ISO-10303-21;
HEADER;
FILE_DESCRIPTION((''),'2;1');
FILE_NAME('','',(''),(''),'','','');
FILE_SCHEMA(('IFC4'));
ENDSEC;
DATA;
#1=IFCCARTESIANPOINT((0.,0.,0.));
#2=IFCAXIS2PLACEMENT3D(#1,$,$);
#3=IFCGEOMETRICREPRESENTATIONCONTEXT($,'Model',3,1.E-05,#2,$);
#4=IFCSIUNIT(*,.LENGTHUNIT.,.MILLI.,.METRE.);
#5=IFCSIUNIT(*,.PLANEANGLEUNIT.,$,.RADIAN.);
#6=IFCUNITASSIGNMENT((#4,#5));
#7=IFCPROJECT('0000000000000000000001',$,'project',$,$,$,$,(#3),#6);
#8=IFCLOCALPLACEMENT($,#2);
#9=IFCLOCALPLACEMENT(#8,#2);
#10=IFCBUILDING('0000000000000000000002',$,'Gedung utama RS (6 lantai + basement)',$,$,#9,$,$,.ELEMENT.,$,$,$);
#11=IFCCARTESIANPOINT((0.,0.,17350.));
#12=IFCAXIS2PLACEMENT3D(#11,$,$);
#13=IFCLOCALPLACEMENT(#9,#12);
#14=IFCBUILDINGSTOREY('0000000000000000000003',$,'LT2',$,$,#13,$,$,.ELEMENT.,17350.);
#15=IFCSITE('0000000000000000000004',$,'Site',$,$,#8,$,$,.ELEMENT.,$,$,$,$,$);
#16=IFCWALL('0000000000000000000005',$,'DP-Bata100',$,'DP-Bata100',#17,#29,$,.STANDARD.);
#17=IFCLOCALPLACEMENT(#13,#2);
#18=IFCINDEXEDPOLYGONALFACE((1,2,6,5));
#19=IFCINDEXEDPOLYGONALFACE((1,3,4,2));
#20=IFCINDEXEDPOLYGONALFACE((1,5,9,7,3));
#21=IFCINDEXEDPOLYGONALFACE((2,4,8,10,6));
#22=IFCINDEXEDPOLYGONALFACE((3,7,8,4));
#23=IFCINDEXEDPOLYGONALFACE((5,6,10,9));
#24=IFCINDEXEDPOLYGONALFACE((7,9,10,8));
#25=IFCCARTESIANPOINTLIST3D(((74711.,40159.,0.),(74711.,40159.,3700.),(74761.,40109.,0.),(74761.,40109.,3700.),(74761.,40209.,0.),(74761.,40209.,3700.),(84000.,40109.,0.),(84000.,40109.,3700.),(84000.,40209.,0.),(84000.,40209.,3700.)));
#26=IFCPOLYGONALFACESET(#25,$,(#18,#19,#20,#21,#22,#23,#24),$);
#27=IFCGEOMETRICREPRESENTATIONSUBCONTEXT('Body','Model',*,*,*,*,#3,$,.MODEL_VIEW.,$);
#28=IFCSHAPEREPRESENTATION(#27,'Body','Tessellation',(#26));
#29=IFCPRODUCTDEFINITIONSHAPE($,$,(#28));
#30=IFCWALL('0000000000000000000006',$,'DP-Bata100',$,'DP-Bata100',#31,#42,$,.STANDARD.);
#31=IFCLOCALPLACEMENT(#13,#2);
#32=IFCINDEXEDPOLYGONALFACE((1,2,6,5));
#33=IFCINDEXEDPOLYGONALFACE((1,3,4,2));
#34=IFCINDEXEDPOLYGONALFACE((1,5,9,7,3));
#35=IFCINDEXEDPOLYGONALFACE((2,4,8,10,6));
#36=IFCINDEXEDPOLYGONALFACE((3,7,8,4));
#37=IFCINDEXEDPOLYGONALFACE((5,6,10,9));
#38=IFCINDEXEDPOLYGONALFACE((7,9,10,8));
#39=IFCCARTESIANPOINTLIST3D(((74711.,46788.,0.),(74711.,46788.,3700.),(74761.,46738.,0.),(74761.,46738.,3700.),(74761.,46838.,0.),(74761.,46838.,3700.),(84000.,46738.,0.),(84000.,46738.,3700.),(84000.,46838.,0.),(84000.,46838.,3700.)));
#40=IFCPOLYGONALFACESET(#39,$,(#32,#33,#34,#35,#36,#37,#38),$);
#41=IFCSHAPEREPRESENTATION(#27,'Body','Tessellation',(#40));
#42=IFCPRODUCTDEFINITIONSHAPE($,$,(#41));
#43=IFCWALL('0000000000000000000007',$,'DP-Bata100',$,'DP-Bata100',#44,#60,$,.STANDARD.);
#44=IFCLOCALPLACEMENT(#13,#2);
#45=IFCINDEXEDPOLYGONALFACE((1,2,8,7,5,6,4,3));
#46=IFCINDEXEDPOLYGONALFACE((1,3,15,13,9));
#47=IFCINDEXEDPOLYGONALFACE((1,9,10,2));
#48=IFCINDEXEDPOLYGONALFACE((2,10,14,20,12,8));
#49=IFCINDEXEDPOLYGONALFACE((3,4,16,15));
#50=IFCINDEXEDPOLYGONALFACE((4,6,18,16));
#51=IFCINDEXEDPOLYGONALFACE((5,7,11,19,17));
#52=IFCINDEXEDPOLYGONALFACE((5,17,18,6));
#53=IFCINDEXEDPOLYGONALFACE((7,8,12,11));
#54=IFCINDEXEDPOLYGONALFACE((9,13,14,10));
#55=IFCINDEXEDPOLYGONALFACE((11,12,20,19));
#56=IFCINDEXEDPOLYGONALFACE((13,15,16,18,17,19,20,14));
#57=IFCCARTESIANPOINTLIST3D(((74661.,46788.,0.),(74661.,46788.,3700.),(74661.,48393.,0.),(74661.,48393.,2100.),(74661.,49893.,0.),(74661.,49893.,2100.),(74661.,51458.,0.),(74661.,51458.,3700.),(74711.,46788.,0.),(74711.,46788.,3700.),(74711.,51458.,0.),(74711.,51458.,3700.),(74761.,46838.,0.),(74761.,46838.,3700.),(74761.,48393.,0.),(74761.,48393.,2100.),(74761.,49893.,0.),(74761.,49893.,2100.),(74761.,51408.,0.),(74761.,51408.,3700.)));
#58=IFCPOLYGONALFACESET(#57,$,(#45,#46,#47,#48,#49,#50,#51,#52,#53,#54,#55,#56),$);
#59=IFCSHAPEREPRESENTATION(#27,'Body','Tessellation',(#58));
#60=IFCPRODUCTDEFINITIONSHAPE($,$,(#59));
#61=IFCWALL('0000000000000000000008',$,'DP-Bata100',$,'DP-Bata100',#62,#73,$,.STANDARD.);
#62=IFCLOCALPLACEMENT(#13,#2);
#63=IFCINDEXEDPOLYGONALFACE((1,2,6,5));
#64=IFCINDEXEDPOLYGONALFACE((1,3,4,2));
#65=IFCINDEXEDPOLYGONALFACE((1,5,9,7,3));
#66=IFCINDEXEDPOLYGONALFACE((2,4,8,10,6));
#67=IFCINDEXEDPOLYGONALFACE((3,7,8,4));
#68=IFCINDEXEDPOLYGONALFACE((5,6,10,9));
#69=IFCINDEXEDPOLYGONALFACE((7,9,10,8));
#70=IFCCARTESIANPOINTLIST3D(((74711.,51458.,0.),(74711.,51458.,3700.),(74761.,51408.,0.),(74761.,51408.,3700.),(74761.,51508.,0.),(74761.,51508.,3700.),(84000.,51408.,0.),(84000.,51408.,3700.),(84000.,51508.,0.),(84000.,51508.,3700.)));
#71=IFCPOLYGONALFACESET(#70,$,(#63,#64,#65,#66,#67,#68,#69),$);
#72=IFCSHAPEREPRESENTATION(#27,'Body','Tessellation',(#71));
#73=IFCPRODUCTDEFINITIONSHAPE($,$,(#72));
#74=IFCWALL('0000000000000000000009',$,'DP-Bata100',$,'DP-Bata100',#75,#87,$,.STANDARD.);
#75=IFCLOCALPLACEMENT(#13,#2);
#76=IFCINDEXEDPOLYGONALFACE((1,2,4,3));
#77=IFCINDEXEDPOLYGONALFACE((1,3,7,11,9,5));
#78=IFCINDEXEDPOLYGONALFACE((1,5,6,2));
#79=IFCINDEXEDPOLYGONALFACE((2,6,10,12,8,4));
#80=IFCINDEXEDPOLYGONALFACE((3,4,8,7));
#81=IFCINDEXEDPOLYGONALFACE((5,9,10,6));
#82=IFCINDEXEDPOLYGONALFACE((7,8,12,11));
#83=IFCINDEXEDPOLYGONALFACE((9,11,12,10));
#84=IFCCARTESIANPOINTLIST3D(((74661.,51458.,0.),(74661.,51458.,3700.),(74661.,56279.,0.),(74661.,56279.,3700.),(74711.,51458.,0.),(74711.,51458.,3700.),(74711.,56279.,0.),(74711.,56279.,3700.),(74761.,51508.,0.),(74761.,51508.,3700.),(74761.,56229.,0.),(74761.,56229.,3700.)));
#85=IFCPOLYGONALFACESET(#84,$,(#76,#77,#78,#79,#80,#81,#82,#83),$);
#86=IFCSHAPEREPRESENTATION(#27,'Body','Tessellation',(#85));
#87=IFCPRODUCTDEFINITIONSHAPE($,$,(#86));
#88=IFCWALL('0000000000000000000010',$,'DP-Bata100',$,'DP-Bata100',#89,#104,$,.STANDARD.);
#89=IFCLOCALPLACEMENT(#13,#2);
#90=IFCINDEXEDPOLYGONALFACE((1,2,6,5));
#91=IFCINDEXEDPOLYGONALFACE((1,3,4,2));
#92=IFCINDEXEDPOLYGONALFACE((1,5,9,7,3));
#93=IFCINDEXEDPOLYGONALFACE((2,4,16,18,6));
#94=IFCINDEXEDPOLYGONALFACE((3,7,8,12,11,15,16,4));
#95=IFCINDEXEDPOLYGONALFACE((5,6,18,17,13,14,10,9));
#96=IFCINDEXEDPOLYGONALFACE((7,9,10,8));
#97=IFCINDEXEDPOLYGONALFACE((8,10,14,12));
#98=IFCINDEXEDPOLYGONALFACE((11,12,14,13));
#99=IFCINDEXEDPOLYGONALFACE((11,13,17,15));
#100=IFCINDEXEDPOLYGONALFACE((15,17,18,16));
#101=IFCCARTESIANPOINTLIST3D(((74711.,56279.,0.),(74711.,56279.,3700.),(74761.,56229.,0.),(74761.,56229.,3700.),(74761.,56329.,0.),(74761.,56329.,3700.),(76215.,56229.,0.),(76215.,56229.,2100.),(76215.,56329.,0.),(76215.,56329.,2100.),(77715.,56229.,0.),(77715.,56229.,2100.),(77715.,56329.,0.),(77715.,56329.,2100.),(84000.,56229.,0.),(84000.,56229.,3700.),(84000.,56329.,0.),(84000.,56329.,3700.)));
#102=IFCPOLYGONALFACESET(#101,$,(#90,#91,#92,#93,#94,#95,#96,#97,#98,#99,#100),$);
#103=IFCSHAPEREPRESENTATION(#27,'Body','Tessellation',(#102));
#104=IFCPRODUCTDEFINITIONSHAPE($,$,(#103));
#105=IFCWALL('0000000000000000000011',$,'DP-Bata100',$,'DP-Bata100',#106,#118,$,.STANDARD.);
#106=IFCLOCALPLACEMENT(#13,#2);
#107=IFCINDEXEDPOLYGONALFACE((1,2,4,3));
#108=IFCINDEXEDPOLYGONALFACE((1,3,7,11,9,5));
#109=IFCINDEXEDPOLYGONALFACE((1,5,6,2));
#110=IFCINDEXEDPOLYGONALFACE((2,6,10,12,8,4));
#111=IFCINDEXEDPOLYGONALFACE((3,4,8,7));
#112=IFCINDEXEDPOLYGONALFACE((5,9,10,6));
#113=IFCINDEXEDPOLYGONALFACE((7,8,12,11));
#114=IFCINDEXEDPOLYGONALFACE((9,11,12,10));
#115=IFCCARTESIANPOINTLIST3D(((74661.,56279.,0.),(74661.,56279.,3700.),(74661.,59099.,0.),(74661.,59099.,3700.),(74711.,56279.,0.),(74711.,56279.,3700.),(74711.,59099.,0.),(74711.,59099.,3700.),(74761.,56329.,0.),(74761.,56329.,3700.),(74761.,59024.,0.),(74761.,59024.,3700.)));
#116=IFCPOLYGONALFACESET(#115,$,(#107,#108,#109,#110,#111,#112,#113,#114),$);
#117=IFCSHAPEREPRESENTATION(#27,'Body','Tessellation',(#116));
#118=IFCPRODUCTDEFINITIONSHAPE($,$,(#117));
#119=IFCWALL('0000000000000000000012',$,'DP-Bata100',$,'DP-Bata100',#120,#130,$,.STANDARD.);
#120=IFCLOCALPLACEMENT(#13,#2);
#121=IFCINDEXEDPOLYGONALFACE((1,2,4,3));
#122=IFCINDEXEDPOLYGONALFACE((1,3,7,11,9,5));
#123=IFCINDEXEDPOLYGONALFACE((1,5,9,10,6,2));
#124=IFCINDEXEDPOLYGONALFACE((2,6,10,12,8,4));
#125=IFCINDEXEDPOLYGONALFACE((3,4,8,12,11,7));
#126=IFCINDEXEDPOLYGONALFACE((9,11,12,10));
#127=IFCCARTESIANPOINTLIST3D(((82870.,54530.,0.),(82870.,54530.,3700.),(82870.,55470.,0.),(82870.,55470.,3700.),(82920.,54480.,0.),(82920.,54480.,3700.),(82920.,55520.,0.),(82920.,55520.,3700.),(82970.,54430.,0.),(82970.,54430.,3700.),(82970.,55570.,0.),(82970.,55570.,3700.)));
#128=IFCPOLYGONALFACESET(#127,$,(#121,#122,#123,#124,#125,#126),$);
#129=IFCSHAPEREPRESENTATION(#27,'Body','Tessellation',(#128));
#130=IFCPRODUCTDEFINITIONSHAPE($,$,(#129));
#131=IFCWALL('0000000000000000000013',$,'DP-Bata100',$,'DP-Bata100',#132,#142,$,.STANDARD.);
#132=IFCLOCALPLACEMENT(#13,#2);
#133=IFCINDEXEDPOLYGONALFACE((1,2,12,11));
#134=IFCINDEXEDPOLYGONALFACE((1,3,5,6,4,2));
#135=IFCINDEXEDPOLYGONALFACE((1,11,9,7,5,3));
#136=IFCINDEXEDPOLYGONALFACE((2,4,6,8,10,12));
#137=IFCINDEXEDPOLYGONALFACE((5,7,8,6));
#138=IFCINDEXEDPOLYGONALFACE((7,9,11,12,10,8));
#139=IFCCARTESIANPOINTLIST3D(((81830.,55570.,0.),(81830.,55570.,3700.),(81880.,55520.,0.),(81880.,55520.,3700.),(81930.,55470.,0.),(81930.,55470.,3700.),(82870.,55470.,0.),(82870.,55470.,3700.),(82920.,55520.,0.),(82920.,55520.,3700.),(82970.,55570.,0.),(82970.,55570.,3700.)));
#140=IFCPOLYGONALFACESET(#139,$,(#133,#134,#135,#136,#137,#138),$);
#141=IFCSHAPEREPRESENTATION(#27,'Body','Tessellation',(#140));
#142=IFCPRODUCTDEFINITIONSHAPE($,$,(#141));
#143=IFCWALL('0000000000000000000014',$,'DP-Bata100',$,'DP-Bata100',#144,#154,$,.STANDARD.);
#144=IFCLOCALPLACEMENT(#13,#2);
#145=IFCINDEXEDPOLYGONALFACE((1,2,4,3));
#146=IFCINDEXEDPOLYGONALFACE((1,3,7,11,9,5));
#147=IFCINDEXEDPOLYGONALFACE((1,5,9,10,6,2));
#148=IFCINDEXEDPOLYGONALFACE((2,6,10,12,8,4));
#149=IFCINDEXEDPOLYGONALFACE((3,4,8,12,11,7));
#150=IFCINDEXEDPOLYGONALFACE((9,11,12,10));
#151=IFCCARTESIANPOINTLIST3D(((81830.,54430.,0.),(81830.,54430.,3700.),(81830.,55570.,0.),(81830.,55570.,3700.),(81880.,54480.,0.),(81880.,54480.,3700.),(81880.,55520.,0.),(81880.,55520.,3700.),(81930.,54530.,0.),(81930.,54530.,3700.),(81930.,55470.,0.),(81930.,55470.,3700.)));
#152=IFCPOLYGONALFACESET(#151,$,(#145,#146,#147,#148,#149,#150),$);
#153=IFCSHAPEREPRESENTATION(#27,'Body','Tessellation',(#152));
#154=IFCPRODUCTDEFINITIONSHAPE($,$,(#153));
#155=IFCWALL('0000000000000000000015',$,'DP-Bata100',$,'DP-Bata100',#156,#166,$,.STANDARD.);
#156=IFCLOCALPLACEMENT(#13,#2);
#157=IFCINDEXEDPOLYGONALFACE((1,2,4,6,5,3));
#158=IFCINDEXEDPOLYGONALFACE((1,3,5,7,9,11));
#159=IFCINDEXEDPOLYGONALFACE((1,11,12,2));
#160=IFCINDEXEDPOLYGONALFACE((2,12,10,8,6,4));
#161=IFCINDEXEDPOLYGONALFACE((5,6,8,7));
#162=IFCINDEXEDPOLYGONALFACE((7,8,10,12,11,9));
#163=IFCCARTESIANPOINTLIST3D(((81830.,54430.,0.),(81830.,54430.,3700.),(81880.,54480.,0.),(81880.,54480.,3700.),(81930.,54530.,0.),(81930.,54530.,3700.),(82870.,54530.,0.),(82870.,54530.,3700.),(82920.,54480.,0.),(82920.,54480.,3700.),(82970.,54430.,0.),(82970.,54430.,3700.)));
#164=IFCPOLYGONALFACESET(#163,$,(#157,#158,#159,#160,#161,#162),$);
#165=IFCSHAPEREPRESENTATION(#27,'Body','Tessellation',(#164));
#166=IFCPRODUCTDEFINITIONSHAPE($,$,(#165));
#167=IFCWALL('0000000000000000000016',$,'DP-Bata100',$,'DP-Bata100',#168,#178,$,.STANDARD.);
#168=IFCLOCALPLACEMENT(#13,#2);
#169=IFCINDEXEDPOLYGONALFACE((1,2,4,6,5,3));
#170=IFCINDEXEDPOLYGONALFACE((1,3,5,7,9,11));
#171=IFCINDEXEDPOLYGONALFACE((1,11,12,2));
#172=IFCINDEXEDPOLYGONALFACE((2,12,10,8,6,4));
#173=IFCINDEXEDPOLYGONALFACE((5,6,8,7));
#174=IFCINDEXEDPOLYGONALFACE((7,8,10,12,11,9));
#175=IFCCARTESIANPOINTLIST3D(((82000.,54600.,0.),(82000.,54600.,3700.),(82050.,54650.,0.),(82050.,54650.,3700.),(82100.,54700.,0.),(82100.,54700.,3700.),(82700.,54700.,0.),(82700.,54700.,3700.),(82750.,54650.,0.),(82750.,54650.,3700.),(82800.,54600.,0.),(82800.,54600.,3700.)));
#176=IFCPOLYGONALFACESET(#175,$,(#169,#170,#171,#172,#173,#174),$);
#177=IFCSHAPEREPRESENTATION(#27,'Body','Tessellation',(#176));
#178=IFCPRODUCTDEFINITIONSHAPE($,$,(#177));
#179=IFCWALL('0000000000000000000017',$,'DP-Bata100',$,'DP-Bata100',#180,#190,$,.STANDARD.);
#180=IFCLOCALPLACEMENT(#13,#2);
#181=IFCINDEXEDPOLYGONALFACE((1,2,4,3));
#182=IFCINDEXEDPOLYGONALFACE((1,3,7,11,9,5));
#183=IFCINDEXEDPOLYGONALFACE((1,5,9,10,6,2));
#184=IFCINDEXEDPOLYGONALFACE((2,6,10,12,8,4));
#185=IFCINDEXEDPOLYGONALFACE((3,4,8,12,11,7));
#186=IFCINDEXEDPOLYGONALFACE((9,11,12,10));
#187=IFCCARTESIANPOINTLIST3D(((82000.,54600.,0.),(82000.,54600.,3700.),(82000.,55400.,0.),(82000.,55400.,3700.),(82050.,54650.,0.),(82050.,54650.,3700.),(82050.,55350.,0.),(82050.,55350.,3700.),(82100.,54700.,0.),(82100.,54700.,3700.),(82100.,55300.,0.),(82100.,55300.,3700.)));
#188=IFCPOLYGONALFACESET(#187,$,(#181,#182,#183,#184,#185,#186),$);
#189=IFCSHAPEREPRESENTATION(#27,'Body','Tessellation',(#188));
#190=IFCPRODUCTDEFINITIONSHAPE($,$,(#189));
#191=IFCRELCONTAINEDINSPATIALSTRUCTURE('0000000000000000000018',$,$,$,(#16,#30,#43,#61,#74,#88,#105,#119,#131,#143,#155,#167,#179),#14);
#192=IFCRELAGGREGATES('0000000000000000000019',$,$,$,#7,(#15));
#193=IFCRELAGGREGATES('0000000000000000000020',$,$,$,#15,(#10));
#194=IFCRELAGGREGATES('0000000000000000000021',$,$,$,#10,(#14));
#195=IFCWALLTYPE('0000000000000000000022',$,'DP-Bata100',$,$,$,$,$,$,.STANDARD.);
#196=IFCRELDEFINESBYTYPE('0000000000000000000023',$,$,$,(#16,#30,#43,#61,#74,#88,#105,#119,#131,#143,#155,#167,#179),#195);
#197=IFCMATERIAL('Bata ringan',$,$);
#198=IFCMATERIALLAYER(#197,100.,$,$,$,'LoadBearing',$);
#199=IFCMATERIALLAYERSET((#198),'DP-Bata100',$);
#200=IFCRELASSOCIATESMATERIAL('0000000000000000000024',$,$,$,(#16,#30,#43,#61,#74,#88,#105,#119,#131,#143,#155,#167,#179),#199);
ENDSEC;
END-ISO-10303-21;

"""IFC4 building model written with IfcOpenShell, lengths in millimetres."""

from ifc_helpers import new_model, si_unit, frame, frame_2d, origin, place, context, subcontext, project, spatial, polyline, rectangle, outline, extrude, material, layer, layer_set, layer_usage, type_object, element, save


model = new_model("IFC4")

# Units and contexts
model_context = context("Model", 3, precision=1e-05, world=origin())
body_context = subcontext(model_context, "Body", "Model", "MODEL_VIEW")
ifc_project = project(units=[si_unit("LENGTHUNIT", "METRE", prefix="MILLI"), si_unit("PLANEANGLEUNIT", "RADIAN")], contexts=[model_context])

# Site, building, storey
site_placement = place(None, origin())
site = spatial("IfcSite", under=ifc_project, at=site_placement, Name="Site", CompositionType="ELEMENT")
building_placement = place(site_placement, origin())
building = spatial("IfcBuilding", under=site, at=building_placement, Name="Gedung utama RS (6 lantai + basement)", CompositionType="ELEMENT")
storey_placement = place(building_placement, frame((0.0, 0.0, 17350.0)))
storey = spatial("IfcBuildingStorey", under=building, at=storey_placement, Name="LT2", CompositionType="ELEMENT", Elevation=17350.0)

# Walls
ifc_material_1 = material(Name="Bata ringan")
ifc_layer_1 = layer(ifc_material_1, 100.0, Category="LoadBearing")
ifc_layer_set_1 = layer_set([ifc_layer_1], Name="DP-Bata100")
ifc_layer_usage_1 = layer_usage(ifc_layer_set_1, "AXIS2", "NEGATIVE", 50.0)
wall_type_1 = type_object("IfcWallType", Name="DP-Bata100", PredefinedType="STANDARD")
for number, where, z_axis, x_axis, name in (
    (1, (84000.0, 40159.0, 0.0), (0.0, 0.0, 1.0), (-1.0, 0.0, 0.0), "DP-Bata100"),
    (2, (84000.0, 46788.0, 0.0), (0.0, 0.0, 1.0), (-1.0, 0.0, 0.0), "DP-Bata100"),
):
    element("IfcWall", number, at=place(storey_placement, frame(where, z_axis=z_axis, x_axis=x_axis)), inside=storey, type_object=wall_type_1, material=ifc_layer_usage_1, Name=name, ObjectType="DP-Bata100", PredefinedType="STANDARD", context=body_context, shape_type="SweptSolid", body=[
        extrude(outline(polyline([(0.0, -50.0), (0.0, 50.0), (9239.0, 50.0), (9289.0, 0.0), (9239.0, -50.0), (0.0, -50.0)])), origin(), (0.0, 0.0, 1.0), 3700.0),
    ])

# Wall, opening
wall_1_placement = place(storey_placement, frame((74711.0, 51458.0, 0.0), z_axis=(0.0, 0.0, 1.0), x_axis=(0.0, -1.0, 0.0)))
wall_1 = element("IfcWall", 3, at=wall_1_placement, inside=storey, type_object=wall_type_1, material=ifc_layer_usage_1, Name="DP-Bata100", ObjectType="DP-Bata100", PredefinedType="STANDARD", context=body_context, shape_type="SweptSolid", body=[
    extrude(outline(polyline([(0.0, -50.0), (0.0, 0.0), (50.0, 50.0), (4620.0, 50.0), (4670.0, 0.0), (4670.0, -50.0), (0.0, -50.0)])), origin(), (0.0, 0.0, 1.0), 3700.0),
])
opening_1_placement = place(wall_1_placement, frame((1565.0, 0.0, 0.0), z_axis=(0.0, 0.0, 1.0), x_axis=(1.0, 0.0, 0.0)))
element("IfcOpeningElement", 4, at=opening_1_placement, cuts=wall_1, PredefinedType="OPENING", context=body_context, shape_type="SweptSolid", body=[
    extrude(rectangle(XDim=1500.0, YDim=120.0, at=frame_2d((750.0, 0.0))), origin(), (0.0, 0.0, 1.0), 2100.0),
])

# Walls
wall_2_placement = place(storey_placement, frame((84000.0, 51458.0, 0.0), z_axis=(0.0, 0.0, 1.0), x_axis=(-1.0, 0.0, 0.0)))
element("IfcWall", 5, at=wall_2_placement, inside=storey, type_object=wall_type_1, material=ifc_layer_usage_1, Name="DP-Bata100", ObjectType="DP-Bata100", PredefinedType="STANDARD", context=body_context, shape_type="SweptSolid", body=[
    extrude(outline(polyline([(0.0, -50.0), (0.0, 50.0), (9239.0, 50.0), (9289.0, 0.0), (9239.0, -50.0), (0.0, -50.0)])), origin(), (0.0, 0.0, 1.0), 3700.0),
])
wall_3_placement = place(storey_placement, frame((74711.0, 56279.0, 0.0), z_axis=(0.0, 0.0, 1.0), x_axis=(0.0, -1.0, 0.0)))
element("IfcWall", 6, at=wall_3_placement, inside=storey, type_object=wall_type_1, material=ifc_layer_usage_1, Name="DP-Bata100", ObjectType="DP-Bata100", PredefinedType="STANDARD", context=body_context, shape_type="SweptSolid", body=[
    extrude(outline(polyline([(0.0, -50.0), (0.0, 0.0), (50.0, 50.0), (4771.0, 50.0), (4821.0, 0.0), (4821.0, -50.0), (0.0, -50.0)])), origin(), (0.0, 0.0, 1.0), 3700.0),
])

# Wall, opening
wall_4_placement = place(storey_placement, frame((74711.0, 56279.0, 0.0), z_axis=(0.0, 0.0, 1.0), x_axis=(1.0, 0.0, 0.0)))
wall_4 = element("IfcWall", 7, at=wall_4_placement, inside=storey, type_object=wall_type_1, material=ifc_layer_usage_1, Name="DP-Bata100", ObjectType="DP-Bata100", PredefinedType="STANDARD", context=body_context, shape_type="SweptSolid", body=[
    extrude(outline(polyline([(50.0, -50.0), (0.0, 0.0), (50.0, 50.0), (9289.0, 50.0), (9289.0, -50.0), (50.0, -50.0)])), origin(), (0.0, 0.0, 1.0), 3700.0),
])
opening_2_placement = place(wall_4_placement, frame((1504.0, 0.0, 0.0), z_axis=(0.0, 0.0, 1.0), x_axis=(1.0, 0.0, 0.0)))
element("IfcOpeningElement", 8, at=opening_2_placement, cuts=wall_4, PredefinedType="OPENING", context=body_context, shape_type="SweptSolid", body=[
    extrude(rectangle(XDim=1500.0, YDim=120.0, at=frame_2d((750.0, 0.0))), origin(), (0.0, 0.0, 1.0), 2100.0),
])

# Walls
wall_5_placement = place(storey_placement, frame((74711.0, 59099.0, 0.0), z_axis=(0.0, 0.0, 1.0), x_axis=(0.0, -1.0, 0.0)))
element("IfcWall", 9, at=wall_5_placement, inside=storey, type_object=wall_type_1, material=ifc_layer_usage_1, Name="DP-Bata100", ObjectType="DP-Bata100", PredefinedType="STANDARD", context=body_context, shape_type="SweptSolid", body=[
    extrude(outline(polyline([(0.0, -50.0), (0.0, 0.0), (75.0, 50.0), (2770.0, 50.0), (2820.0, 0.0), (2820.0, -50.0), (0.0, -50.0)])), origin(), (0.0, 0.0, 1.0), 3700.0),
])
for number, where, z_axis, x_axis, name in (
    (10, (82920.0, 54480.0, 0.0), (0.0, 0.0, 1.0), (0.0, 1.0, 0.0), "DP-Bata100"),
    (11, (82920.0, 55520.0, 0.0), (0.0, 0.0, 1.0), (-1.0, 0.0, 0.0), "DP-Bata100"),
    (12, (81880.0, 55520.0, 0.0), (0.0, 0.0, 1.0), (0.0, -1.0, 0.0), "DP-Bata100"),
    (13, (81880.0, 54480.0, 0.0), (0.0, 0.0, 1.0), (1.0, 0.0, 0.0), "DP-Bata100"),
):
    element("IfcWall", number, at=place(storey_placement, frame(where, z_axis=z_axis, x_axis=x_axis)), inside=storey, type_object=wall_type_1, material=ifc_layer_usage_1, Name=name, ObjectType="DP-Bata100", PredefinedType="STANDARD", context=body_context, shape_type="SweptSolid", body=[
        extrude(outline(polyline([(-50.0, -50.0), (0.0, 0.0), (50.0, 50.0), (990.0, 50.0), (1040.0, 0.0), (1090.0, -50.0), (-50.0, -50.0)])), origin(), (0.0, 0.0, 1.0), 3700.0),
    ])
for number, where, z_axis, x_axis, name in (
    (14, (82750.0, 54650.0, 0.0), (0.0, 0.0, 1.0), (-1.0, 0.0, 0.0), "DP-Bata100"),
    (15, (82050.0, 54650.0, 0.0), (0.0, 0.0, 1.0), (0.0, 1.0, 0.0), "DP-Bata100"),
):
    element("IfcWall", number, at=place(storey_placement, frame(where, z_axis=z_axis, x_axis=x_axis)), inside=storey, type_object=wall_type_1, material=ifc_layer_usage_1, Name=name, ObjectType="DP-Bata100", PredefinedType="STANDARD", context=body_context, shape_type="SweptSolid", body=[
        extrude(outline(polyline([(50.0, -50.0), (0.0, 0.0), (-50.0, 50.0), (750.0, 50.0), (700.0, 0.0), (650.0, -50.0), (50.0, -50.0)])), origin(), (0.0, 0.0, 1.0), 3700.0),
    ])

save(model, "model.ifc")
